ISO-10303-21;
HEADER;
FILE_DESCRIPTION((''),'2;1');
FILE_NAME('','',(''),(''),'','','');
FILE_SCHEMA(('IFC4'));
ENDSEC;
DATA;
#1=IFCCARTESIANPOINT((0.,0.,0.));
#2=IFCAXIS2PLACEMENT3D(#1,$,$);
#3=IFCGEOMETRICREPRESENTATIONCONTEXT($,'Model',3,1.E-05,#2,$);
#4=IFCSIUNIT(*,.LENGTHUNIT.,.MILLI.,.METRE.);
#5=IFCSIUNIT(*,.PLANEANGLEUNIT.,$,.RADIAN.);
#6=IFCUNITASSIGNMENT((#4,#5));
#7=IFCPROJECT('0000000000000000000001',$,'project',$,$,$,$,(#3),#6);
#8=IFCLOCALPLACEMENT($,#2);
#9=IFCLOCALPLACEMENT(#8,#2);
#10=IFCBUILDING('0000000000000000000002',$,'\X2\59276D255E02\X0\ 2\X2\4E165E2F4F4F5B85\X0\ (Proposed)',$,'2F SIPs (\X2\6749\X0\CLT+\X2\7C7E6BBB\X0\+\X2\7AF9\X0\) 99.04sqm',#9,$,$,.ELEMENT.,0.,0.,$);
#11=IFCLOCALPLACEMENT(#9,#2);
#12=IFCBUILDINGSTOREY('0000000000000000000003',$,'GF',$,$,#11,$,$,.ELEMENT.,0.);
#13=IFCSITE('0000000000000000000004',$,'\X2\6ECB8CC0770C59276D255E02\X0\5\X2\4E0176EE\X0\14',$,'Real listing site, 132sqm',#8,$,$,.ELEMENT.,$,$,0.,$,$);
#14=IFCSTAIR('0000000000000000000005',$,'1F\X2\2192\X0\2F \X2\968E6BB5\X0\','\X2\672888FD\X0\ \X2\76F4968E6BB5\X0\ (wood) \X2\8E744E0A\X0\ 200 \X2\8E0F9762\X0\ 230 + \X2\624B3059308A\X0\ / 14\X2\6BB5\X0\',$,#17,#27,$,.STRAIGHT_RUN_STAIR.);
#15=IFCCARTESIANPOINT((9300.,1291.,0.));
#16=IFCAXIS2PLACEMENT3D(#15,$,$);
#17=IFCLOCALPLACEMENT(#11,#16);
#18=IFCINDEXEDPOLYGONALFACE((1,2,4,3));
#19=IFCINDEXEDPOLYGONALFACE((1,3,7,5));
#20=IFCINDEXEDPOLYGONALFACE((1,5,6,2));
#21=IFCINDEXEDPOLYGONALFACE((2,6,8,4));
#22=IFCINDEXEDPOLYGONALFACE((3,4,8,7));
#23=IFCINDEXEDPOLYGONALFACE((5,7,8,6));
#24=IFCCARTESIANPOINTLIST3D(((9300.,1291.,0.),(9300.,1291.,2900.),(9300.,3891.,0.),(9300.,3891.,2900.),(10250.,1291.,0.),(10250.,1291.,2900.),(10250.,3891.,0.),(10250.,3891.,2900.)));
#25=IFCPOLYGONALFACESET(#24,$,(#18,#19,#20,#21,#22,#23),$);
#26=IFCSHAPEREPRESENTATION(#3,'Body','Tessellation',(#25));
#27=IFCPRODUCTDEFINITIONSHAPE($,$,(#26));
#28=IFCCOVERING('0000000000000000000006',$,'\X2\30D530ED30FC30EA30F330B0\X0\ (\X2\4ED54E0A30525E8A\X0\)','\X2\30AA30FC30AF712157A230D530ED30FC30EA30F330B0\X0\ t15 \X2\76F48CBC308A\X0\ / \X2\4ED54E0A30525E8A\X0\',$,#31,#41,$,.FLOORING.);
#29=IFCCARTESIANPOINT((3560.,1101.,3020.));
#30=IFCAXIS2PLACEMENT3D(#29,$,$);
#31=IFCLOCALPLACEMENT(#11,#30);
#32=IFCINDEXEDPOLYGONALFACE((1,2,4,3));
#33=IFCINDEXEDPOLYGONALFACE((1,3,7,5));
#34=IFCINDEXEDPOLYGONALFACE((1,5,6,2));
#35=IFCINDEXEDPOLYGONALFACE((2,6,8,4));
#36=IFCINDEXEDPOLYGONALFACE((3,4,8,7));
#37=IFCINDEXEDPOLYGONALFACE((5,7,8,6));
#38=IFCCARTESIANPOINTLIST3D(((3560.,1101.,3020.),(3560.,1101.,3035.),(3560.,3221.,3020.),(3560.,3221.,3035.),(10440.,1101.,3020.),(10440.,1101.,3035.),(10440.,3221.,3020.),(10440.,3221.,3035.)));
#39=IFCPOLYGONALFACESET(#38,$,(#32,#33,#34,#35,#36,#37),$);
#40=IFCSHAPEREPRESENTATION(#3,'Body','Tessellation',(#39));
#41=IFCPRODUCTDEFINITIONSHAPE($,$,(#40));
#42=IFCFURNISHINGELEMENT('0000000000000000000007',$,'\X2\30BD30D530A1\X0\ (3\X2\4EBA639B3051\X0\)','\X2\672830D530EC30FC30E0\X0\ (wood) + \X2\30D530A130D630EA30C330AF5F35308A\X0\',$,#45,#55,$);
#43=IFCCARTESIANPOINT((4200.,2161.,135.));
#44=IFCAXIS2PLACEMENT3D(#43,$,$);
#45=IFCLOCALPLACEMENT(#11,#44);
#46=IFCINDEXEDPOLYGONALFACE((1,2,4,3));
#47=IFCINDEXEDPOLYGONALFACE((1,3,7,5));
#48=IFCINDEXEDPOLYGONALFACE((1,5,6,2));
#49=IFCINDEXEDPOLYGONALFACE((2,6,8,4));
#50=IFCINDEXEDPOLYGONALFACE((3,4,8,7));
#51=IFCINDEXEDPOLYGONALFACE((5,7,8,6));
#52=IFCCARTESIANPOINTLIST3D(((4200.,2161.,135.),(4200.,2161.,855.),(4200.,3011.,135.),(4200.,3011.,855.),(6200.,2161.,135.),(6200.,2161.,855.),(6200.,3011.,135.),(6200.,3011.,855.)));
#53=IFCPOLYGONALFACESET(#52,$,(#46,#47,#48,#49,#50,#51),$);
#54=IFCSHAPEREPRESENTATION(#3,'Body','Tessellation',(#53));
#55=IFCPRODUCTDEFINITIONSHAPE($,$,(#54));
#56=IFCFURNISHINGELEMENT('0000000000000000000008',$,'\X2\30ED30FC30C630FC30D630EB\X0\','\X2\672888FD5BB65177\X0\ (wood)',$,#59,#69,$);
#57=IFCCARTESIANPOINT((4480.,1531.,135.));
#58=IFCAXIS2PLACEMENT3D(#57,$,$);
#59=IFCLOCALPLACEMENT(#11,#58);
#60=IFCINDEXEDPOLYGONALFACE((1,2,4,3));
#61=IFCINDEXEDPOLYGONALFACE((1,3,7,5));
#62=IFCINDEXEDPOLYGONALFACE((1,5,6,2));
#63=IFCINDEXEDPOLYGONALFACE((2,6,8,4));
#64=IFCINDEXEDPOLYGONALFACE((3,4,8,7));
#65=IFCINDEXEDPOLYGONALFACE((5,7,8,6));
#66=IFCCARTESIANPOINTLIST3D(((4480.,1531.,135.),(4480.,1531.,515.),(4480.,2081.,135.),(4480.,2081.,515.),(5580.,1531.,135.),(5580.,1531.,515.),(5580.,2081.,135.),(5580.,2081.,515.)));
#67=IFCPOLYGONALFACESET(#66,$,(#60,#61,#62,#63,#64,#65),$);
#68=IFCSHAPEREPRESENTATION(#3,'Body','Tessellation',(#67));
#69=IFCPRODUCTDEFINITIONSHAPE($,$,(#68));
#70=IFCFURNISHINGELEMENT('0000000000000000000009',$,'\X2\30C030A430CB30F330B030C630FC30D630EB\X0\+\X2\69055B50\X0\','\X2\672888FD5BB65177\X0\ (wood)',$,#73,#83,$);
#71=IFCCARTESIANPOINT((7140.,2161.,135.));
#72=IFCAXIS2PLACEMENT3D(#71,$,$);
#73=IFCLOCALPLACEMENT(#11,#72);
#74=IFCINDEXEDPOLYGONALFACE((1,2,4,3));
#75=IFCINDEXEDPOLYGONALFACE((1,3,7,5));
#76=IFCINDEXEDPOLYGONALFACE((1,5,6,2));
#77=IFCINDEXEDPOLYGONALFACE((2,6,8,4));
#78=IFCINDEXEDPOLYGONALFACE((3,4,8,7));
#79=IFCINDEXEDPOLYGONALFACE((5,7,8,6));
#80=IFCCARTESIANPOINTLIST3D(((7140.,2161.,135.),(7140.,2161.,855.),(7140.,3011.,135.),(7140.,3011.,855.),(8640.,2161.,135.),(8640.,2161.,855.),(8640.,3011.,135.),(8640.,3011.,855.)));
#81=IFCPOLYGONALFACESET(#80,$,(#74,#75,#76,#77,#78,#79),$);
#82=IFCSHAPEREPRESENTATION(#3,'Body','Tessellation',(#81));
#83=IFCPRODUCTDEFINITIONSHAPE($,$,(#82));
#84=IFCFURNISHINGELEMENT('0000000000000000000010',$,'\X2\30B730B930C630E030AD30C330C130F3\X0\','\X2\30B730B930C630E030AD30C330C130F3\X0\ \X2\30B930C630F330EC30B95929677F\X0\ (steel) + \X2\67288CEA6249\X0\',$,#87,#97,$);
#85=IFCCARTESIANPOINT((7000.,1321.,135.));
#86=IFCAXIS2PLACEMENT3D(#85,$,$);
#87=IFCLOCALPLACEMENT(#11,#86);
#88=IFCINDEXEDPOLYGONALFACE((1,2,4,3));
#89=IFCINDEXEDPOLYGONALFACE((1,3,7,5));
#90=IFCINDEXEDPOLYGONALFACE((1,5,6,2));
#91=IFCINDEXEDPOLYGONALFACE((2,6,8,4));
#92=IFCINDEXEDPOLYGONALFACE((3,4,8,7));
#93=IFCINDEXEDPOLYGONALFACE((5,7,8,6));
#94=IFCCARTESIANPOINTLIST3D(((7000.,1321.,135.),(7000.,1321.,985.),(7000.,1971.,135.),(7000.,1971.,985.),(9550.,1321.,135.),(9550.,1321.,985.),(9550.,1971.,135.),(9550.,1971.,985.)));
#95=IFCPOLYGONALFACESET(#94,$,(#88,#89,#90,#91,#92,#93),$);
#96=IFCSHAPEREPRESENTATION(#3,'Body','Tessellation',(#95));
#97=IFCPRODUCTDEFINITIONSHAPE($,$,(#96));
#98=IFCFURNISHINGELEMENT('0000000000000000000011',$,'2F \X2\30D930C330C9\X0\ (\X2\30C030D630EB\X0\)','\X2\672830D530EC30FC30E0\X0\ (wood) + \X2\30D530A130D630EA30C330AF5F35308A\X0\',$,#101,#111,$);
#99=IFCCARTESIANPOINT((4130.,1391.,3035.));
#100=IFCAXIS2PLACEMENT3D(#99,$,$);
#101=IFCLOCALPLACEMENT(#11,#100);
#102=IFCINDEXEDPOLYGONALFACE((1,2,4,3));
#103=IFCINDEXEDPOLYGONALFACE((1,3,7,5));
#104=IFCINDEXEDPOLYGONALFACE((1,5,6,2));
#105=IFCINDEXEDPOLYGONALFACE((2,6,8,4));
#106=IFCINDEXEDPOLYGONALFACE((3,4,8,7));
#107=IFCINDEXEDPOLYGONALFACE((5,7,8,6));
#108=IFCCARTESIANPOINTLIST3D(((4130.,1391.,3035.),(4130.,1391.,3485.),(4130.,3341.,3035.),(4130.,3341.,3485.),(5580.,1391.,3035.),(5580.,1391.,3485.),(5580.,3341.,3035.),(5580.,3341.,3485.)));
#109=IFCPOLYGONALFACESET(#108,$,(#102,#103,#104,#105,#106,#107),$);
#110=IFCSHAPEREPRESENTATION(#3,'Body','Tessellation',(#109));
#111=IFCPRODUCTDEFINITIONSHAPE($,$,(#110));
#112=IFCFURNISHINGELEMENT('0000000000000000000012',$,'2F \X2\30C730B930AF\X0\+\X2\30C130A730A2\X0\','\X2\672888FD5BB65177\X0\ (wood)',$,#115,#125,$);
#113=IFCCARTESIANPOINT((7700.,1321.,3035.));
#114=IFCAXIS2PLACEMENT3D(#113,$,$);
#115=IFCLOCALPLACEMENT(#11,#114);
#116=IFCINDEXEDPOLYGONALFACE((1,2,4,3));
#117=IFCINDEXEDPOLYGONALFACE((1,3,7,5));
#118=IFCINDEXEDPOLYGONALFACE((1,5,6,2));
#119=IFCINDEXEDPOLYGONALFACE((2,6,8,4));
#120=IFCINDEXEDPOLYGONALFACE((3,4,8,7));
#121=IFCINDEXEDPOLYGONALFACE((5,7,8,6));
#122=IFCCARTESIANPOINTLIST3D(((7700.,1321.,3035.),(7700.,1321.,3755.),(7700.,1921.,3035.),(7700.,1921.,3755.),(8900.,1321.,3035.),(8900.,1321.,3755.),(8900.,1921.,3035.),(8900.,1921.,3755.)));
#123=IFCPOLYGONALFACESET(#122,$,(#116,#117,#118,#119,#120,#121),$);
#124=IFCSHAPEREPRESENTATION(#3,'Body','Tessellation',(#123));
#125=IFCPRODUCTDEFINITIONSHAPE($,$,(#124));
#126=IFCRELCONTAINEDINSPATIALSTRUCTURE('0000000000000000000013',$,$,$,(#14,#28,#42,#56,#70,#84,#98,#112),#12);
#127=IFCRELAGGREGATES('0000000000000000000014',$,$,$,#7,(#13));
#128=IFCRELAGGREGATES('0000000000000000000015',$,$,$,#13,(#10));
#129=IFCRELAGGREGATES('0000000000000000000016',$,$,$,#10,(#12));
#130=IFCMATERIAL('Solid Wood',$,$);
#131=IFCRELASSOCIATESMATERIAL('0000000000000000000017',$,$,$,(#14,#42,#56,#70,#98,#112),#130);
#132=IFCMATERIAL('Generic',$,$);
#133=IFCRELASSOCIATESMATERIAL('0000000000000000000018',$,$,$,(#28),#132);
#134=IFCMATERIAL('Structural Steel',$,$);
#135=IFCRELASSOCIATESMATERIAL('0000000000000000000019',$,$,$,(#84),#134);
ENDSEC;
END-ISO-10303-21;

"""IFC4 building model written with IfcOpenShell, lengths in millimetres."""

from ifc_helpers import new_model, si_unit, frame, frame_2d, origin, place, context, project, spatial, rectangle, extrude, material, element, save


model = new_model("IFC4")

# Units and contexts
model_context = context("Model", 3, precision=1e-05, world=origin())
ifc_project = project(units=[si_unit("LENGTHUNIT", "METRE", prefix="MILLI"), si_unit("PLANEANGLEUNIT", "RADIAN")], contexts=[model_context])

# Site, building, storey
site_placement = place(None, origin())
site = spatial("IfcSite", under=ifc_project, at=site_placement, Name="滋賀県大津市5丁目14", ObjectType="Real listing site, 132sqm", CompositionType="ELEMENT", RefElevation=0.0)
building_placement = place(site_placement, origin())
building = spatial("IfcBuilding", under=site, at=building_placement, Name="大津市 2世帯住宅 (Proposed)", ObjectType="2F SIPs (杉CLT+籾殻+竹) 99.04sqm", CompositionType="ELEMENT", ElevationOfRefHeight=0.0, ElevationOfTerrain=0.0)
storey_placement = place(building_placement, origin())
storey = spatial("IfcBuildingStorey", under=building, at=storey_placement, Name="GF", CompositionType="ELEMENT", Elevation=0.0)

# Shared definitions
ifc_material_1 = material(Name="Solid Wood")

# Shared definitions
ifc_material_2 = material(Name="Generic")

# Stair
stair_placement = place(storey_placement, frame((9300.0, 1291.0, 0.0)))
element("IfcStair", 1, at=stair_placement, inside=storey, material=ifc_material_1, Name="1F→2F 階段", Description="木製 直階段 (wood) 蹴上 200 踏面 230 + 手すり / 14段", PredefinedType="STRAIGHT_RUN_STAIR", context=model_context, shape_type="SweptSolid", body=[
    extrude(rectangle(XDim=950.0, YDim=2600.0, at=frame_2d((475.0, 1300.0))), frame((9300.0, 1291.0, 0.0)), (0.0, 0.0, 1.0), 2900.0),
])

# Covering
covering_placement = place(storey_placement, frame((3560.0, 1101.0, 3020.0)))
element("IfcCovering", 2, at=covering_placement, inside=storey, material=ifc_material_2, Name="フローリング (仕上げ床)", Description="オーク無垢フローリング t15 直貼り / 仕上げ床", PredefinedType="FLOORING", context=model_context, shape_type="SweptSolid", body=[
    extrude(rectangle(XDim=6880.0, YDim=2120.0, at=frame_2d((3440.0, 1060.0))), frame((3560.0, 1101.0, 3020.0)), (0.0, 0.0, 1.0), 15.0),
])

# Furnishing elements
furnishing_1_placement = place(storey_placement, frame((4200.0, 2161.0, 135.0)))
element("IfcFurnishingElement", 3, at=furnishing_1_placement, inside=storey, material=ifc_material_1, Name="ソファ (3人掛け)", Description="木フレーム (wood) + ファブリック張り", context=model_context, shape_type="SweptSolid", body=[
    extrude(rectangle(XDim=2000.0, YDim=850.0, at=frame_2d((1000.0, 425.0))), frame((4200.0, 2161.0, 135.0)), (0.0, 0.0, 1.0), 720.0),
])
furnishing_2_placement = place(storey_placement, frame((4480.0, 1531.0, 135.0)))
element("IfcFurnishingElement", 4, at=furnishing_2_placement, inside=storey, material=ifc_material_1, Name="ローテーブル", Description="木製家具 (wood)", context=model_context, shape_type="SweptSolid", body=[
    extrude(rectangle(XDim=1100.0, YDim=550.0, at=frame_2d((550.0, 275.0))), frame((4480.0, 1531.0, 135.0)), (0.0, 0.0, 1.0), 380.0),
])
furnishing_3_placement = place(storey_placement, frame((7140.0, 2161.0, 135.0)))
element("IfcFurnishingElement", 5, at=furnishing_3_placement, inside=storey, material=ifc_material_1, Name="ダイニングテーブル+椅子", Description="木製家具 (wood)", context=model_context, shape_type="SweptSolid", body=[
    extrude(rectangle(XDim=1500.0, YDim=850.0, at=frame_2d((750.0, 425.0))), frame((7140.0, 2161.0, 135.0)), (0.0, 0.0, 1.0), 720.0),
])
ifc_material_3 = material(Name="Structural Steel")
furnishing_4_placement = place(storey_placement, frame((7000.0, 1321.0, 135.0)))
element("IfcFurnishingElement", 6, at=furnishing_4_placement, inside=storey, material=ifc_material_3, Name="システムキッチン", Description="システムキッチン ステンレス天板 (steel) + 木質扉", context=model_context, shape_type="SweptSolid", body=[
    extrude(rectangle(XDim=2550.0, YDim=650.0, at=frame_2d((1275.0, 325.0))), frame((7000.0, 1321.0, 135.0)), (0.0, 0.0, 1.0), 850.0),
])
furnishing_5_placement = place(storey_placement, frame((4130.0, 1391.0, 3035.0)))
element("IfcFurnishingElement", 7, at=furnishing_5_placement, inside=storey, material=ifc_material_1, Name="2F ベッド (ダブル)", Description="木フレーム (wood) + ファブリック張り", context=model_context, shape_type="SweptSolid", body=[
    extrude(rectangle(XDim=1450.0, YDim=1950.0, at=frame_2d((725.0, 975.0))), frame((4130.0, 1391.0, 3035.0)), (0.0, 0.0, 1.0), 450.0),
])
furnishing_6_placement = place(storey_placement, frame((7700.0, 1321.0, 3035.0)))
element("IfcFurnishingElement", 8, at=furnishing_6_placement, inside=storey, material=ifc_material_1, Name="2F デスク+チェア", Description="木製家具 (wood)", context=model_context, shape_type="SweptSolid", body=[
    extrude(rectangle(XDim=1200.0, YDim=600.0, at=frame_2d((600.0, 300.0))), frame((7700.0, 1321.0, 3035.0)), (0.0, 0.0, 1.0), 720.0),
])

save(model, "model.ifc")
